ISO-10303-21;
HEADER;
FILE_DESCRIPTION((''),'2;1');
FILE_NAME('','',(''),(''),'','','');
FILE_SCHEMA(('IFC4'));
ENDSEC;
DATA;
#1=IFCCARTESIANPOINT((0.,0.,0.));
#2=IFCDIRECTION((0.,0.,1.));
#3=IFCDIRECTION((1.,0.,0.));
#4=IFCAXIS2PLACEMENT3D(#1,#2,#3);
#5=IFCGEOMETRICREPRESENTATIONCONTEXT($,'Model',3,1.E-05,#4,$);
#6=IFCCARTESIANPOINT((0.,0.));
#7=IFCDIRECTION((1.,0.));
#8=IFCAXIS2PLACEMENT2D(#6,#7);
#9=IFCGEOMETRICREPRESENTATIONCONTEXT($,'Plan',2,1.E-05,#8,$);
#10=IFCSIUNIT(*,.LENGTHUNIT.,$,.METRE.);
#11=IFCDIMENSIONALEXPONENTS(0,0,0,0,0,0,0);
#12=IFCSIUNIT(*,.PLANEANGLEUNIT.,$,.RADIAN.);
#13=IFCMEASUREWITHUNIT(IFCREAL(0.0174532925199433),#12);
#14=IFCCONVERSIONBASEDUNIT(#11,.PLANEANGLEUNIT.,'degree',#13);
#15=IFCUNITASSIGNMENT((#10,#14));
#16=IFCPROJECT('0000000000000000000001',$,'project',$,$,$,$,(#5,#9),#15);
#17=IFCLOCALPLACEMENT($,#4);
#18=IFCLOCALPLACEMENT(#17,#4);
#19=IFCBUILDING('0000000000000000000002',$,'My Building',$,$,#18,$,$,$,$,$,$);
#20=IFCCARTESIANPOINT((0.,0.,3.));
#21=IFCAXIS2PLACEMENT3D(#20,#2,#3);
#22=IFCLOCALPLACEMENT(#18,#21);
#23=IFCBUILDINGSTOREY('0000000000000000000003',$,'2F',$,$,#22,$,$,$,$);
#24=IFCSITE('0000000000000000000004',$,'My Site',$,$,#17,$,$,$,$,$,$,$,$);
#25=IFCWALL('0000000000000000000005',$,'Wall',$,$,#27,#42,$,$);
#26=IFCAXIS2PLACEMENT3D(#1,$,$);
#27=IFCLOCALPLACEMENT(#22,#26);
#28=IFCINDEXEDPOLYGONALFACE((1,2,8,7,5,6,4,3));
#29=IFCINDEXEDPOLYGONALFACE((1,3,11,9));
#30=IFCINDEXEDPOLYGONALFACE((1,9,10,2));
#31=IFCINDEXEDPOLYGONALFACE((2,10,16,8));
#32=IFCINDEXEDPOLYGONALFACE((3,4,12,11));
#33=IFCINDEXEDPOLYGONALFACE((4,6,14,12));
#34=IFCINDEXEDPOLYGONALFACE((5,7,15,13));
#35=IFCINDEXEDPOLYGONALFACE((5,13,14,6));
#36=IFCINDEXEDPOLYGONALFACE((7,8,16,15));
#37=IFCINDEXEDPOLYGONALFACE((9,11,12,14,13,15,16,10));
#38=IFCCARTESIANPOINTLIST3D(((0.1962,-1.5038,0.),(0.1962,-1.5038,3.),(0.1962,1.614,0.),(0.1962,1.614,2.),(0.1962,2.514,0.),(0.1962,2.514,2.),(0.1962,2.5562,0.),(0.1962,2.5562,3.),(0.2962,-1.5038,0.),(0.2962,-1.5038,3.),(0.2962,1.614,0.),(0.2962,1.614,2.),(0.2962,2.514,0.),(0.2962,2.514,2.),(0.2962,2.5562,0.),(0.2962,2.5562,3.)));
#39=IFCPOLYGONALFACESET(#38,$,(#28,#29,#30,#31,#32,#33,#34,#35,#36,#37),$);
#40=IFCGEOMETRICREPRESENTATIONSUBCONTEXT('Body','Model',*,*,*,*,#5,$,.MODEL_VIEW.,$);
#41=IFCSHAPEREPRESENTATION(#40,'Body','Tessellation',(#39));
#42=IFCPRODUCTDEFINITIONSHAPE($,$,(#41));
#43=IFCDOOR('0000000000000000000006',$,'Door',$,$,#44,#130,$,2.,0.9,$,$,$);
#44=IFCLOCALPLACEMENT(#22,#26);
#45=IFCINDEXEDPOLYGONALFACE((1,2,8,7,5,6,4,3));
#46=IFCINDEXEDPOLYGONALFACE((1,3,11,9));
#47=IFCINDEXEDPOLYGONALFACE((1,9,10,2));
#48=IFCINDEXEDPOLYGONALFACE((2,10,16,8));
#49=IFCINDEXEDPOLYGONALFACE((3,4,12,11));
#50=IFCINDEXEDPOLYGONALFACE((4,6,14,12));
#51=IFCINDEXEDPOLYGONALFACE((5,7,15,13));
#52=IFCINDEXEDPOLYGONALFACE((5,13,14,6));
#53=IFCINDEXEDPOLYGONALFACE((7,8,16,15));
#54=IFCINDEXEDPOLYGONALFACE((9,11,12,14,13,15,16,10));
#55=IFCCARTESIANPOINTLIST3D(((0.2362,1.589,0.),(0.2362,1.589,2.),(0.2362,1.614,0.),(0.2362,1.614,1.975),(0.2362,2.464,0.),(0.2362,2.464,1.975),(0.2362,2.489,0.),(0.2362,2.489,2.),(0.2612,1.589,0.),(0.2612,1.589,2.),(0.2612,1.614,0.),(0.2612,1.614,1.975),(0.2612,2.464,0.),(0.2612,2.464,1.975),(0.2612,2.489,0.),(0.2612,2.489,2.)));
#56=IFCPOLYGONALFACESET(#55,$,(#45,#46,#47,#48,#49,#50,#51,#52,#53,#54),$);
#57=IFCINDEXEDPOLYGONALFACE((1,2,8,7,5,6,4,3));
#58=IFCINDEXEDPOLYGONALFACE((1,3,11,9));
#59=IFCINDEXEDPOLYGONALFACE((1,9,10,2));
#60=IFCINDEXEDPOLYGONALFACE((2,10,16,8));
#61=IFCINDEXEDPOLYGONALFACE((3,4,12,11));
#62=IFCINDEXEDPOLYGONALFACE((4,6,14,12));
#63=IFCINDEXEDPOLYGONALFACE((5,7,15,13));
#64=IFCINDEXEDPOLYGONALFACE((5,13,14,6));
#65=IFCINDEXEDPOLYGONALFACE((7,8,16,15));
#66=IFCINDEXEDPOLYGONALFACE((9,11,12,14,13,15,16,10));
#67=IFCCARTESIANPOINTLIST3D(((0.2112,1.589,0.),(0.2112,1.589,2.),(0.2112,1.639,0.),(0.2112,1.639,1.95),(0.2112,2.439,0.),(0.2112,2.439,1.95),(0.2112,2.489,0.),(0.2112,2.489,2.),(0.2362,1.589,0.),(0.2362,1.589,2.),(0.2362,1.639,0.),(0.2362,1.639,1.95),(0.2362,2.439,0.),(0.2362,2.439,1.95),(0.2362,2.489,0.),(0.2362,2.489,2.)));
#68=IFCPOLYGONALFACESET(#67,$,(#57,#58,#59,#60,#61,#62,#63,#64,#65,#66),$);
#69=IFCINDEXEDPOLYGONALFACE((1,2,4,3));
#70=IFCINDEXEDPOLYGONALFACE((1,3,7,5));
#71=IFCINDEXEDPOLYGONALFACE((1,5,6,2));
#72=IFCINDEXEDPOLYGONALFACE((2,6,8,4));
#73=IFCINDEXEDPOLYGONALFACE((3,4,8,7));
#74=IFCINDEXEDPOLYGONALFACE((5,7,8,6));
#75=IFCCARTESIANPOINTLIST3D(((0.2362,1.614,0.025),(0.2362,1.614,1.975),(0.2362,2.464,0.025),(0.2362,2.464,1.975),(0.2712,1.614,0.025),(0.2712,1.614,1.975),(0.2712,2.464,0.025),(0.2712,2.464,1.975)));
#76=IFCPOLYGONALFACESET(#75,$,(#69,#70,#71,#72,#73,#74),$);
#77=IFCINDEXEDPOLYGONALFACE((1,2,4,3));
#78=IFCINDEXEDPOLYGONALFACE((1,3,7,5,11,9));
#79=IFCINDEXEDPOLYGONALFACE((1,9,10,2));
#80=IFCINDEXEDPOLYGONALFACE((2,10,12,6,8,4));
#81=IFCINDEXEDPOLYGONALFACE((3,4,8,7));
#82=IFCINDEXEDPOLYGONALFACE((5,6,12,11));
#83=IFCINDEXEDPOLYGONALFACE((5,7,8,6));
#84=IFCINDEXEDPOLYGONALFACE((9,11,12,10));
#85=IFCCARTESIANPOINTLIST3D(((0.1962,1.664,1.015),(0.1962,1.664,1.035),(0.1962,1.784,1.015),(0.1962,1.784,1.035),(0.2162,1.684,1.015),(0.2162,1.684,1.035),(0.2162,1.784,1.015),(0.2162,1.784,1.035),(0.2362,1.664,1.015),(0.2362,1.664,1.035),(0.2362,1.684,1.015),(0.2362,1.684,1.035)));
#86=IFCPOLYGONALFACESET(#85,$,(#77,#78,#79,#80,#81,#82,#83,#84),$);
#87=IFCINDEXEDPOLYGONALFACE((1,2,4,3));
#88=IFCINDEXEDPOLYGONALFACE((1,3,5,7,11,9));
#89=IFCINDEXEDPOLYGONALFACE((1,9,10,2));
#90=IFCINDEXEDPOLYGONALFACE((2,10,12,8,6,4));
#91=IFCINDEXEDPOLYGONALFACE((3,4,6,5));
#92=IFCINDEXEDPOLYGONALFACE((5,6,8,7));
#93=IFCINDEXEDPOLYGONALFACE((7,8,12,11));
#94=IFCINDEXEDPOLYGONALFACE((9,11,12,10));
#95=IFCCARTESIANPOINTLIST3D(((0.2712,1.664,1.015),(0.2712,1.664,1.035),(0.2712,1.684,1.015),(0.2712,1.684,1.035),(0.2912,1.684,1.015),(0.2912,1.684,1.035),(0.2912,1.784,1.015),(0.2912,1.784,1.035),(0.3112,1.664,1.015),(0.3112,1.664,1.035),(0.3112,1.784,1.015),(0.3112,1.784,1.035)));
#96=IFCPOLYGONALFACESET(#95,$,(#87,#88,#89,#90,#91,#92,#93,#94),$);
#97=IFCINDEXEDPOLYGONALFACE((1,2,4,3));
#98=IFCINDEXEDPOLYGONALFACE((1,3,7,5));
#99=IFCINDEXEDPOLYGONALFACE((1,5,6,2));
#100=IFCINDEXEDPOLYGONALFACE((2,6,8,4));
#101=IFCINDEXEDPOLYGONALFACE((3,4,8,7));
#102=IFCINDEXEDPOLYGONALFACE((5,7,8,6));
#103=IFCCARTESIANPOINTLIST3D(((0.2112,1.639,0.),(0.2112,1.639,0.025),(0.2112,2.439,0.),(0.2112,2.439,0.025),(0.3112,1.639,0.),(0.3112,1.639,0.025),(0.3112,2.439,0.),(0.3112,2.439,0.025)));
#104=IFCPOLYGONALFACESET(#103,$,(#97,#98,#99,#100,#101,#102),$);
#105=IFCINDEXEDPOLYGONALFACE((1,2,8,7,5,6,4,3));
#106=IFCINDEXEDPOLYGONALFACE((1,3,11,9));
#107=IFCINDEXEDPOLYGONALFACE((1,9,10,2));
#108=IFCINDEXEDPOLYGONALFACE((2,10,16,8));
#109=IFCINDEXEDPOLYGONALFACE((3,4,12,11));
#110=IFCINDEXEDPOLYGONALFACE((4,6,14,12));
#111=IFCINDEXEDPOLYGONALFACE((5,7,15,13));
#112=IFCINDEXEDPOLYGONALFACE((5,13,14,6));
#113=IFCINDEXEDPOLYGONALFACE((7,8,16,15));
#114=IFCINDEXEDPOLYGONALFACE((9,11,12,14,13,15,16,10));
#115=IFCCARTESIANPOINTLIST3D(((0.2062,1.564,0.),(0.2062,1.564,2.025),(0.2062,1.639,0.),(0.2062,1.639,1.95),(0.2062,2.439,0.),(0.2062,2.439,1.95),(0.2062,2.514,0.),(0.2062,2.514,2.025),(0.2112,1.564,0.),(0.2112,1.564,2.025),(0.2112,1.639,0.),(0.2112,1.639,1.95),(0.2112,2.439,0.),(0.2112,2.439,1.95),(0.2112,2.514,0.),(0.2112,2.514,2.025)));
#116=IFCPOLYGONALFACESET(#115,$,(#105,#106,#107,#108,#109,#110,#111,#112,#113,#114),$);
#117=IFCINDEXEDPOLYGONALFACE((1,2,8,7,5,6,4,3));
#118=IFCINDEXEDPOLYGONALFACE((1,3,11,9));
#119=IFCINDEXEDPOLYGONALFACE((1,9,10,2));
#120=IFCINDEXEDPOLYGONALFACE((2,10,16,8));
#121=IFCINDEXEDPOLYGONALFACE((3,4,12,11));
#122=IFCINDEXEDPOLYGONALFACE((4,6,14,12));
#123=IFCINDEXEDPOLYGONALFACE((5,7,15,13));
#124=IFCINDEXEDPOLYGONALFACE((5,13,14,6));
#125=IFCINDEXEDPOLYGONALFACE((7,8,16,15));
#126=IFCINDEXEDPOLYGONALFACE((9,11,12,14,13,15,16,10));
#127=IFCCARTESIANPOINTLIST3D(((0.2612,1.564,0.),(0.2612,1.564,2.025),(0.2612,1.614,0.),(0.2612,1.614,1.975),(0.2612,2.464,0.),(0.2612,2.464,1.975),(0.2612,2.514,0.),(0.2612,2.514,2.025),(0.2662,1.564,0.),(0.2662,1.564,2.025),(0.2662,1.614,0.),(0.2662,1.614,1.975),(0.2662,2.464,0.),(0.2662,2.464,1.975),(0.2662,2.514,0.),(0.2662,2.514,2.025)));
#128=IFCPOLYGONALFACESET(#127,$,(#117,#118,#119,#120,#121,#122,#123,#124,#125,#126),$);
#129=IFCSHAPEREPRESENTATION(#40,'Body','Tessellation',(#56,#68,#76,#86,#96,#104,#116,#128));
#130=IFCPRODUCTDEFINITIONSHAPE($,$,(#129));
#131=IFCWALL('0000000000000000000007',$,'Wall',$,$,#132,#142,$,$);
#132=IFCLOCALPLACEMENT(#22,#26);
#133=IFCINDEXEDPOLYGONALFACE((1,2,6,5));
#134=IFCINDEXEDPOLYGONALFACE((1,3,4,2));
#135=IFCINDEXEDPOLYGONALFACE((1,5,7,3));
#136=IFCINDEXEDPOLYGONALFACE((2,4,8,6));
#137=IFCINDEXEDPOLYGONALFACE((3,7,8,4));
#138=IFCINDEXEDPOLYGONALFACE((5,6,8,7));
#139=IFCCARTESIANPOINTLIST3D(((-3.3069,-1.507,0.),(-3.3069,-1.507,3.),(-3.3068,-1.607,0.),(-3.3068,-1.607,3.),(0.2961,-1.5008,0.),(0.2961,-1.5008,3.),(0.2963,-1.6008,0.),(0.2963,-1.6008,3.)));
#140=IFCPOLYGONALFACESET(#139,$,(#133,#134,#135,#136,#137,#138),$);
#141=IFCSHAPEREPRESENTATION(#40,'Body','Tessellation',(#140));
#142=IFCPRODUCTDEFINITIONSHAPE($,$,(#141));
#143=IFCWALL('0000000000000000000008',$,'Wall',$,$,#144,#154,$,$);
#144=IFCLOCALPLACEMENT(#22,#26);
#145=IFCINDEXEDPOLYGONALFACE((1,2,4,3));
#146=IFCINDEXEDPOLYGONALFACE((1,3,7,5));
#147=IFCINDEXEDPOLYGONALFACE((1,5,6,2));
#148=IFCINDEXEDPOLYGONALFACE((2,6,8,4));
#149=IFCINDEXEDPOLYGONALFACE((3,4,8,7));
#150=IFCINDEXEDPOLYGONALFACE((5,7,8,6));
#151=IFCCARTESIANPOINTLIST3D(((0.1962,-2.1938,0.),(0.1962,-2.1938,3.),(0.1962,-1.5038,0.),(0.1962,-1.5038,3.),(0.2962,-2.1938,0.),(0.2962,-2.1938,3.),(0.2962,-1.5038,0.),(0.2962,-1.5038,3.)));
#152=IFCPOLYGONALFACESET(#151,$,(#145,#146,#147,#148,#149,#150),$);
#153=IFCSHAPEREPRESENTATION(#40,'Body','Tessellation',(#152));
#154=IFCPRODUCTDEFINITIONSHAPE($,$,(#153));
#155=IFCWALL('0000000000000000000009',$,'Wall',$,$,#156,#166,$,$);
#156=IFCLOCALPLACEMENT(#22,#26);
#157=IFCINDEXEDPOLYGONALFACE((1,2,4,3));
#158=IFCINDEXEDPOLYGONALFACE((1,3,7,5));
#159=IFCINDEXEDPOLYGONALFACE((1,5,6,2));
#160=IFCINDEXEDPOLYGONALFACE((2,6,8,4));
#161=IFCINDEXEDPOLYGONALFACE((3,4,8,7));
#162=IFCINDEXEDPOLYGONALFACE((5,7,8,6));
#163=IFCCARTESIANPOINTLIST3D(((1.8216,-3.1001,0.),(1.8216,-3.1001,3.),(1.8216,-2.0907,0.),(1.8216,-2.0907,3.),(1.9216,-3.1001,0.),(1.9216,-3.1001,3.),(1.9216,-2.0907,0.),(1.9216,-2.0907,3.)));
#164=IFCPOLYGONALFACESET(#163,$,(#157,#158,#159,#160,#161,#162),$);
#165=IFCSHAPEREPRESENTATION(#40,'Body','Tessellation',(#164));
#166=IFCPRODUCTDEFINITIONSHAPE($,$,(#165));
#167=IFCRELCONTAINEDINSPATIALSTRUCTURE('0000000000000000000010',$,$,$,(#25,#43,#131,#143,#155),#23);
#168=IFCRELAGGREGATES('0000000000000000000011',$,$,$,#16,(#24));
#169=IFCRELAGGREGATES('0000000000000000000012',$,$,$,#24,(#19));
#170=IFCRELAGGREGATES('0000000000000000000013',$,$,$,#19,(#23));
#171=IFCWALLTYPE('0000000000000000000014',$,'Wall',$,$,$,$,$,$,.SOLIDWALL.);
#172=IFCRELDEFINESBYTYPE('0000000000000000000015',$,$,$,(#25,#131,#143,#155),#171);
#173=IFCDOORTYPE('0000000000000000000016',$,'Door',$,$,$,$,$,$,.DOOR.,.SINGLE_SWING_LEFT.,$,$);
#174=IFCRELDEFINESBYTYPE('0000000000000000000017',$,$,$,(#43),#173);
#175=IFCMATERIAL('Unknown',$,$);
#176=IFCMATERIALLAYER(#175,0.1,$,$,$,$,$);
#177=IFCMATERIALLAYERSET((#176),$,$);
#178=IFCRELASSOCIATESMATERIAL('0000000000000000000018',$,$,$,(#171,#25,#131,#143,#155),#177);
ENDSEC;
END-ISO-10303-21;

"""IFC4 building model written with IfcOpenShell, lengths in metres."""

from ifc_helpers import new_model, entity, si_unit, converted_unit, frame, origin_with_axes, origin_2d_with_axis, place, context, subcontext, project, spatial, line, indexed_curve, outline, extrude, shape, source, transform, mapped, material, layer, layer_set, layer_usage, type_object, type_shapes, element, fill, save


model = new_model("IFC4")

# Units and contexts
model_context = context("Model", 3, precision=1e-05, world=origin_with_axes())
plan_context = context("Plan", 2, precision=1e-05, world=origin_2d_with_axis())
body_context_1 = subcontext(model_context, "Body", "Model", "MODEL_VIEW")
body_context_2 = subcontext(plan_context, "Body", "Plan", "PLAN_VIEW")
ifc_project = project(units=[si_unit("LENGTHUNIT", "METRE"), converted_unit("PLANEANGLEUNIT", "degree", entity("IfcReal", 0.0174532925199433), si_unit("PLANEANGLEUNIT", "RADIAN"), dimensions=[0, 0, 0, 0, 0, 0, 0])], contexts=[model_context, plan_context])

# Site, building, storey
site_placement = place(None, origin_with_axes())
site = spatial("IfcSite", under=ifc_project, at=site_placement, Name="My Site")
building_placement = place(site_placement, origin_with_axes())
building = spatial("IfcBuilding", under=site, at=building_placement, Name="My Building")
storey_placement = place(building_placement, frame((0.0, 0.0, 3.0), z_axis=(0.0, 0.0, 1.0), x_axis=(1.0, 0.0, 0.0)))
storey = spatial("IfcBuildingStorey", under=building, at=storey_placement, Name="2F")

# Shared definitions
ifc_material = material(Name="Unknown")

# Shared definitions
ifc_layer_1 = layer(ifc_material, 0.1)
ifc_layer_set_1 = layer_set([ifc_layer_1])
wall_type = type_object("IfcWallType", Name="Wall", PredefinedType="SOLIDWALL", material=ifc_layer_set_1)

# Wall, opening, door
shared_shape_1 = source(origin_with_axes(), body_context_1, "Body", "SweptSolid", [
    extrude(outline(indexed_curve([(0.0, 0.0), (0.9, 0.0), (0.9, 2.0), (0.0, 2.0)], segments=[line(1, 2, 3, 4, 1)])), frame((0.0, -0.6, 0.0), z_axis=(0.0, -1.0, 0.0), x_axis=(1.0, 0.0, 0.0)), (0.0, 0.0, -1.0), 1.2),
])
door_type_1 = type_object("IfcDoorType", Name="Door", OperationType="SINGLE_SWING_LEFT", PredefinedType="DOOR")
shared_shape_2 = source(origin_with_axes(), body_context_1, "Body", "SweptSolid", [
    extrude(outline(indexed_curve([(0.0, 0.0), (0.0, 2.0), (0.9, 2.0), (0.9, 0.0), (0.875, 0.0), (0.875, 1.975), (0.025, 1.975), (0.025, 0.0)], segments=[line(1, 2, 3, 4, 5, 6, 7, 8, 1)])), frame((0.0, 0.025, 0.0), z_axis=(0.0, -1.0, 0.0), x_axis=(1.0, 0.0, 0.0)), (0.0, 0.0, -1.0), 0.025),
    extrude(outline(indexed_curve([(0.0, 0.0), (0.0, 2.0), (0.9, 2.0), (0.9, 0.0), (0.85, 0.0), (0.85, 1.95), (0.05, 1.95), (0.05, 0.0)], segments=[line(1, 2, 3, 4, 5, 6, 7, 8, 1)])), frame((0.0, 0.0, 0.0), z_axis=(0.0, -1.0, 0.0), x_axis=(1.0, 0.0, 0.0)), (0.0, 0.0, -1.0), 0.025),
    extrude(outline(indexed_curve([(0.0, 0.0), (0.85, 0.0), (0.85, 0.035), (0.0, 0.035)], segments=[line(1, 2, 3, 4, 1)])), frame((0.025, 0.025, 0.025), z_axis=(0.0, 0.0, 1.0), x_axis=(1.0, 0.0, 0.0)), (0.0, 0.0, 1.0), 1.95),
    extrude(outline(indexed_curve([(0.0, 0.0), (0.0, -0.04), (-0.12, -0.04), (-0.12, -0.02), (-0.02, -0.02), (-0.02, 0.0)], segments=[line(1, 2, 3, 4, 5, 6, 1)])), frame((0.825, 0.025, 1.015), z_axis=(0.0, 0.0, 1.0), x_axis=(1.0, 0.0, 0.0)), (0.0, 0.0, 1.0), 0.02),
    extrude(outline(indexed_curve([(0.0, 0.0), (0.0, 0.04), (-0.12, 0.04), (-0.12, 0.02), (-0.02, 0.02), (-0.02, 0.0)], segments=[line(1, 2, 3, 4, 5, 6, 1)])), frame((0.825, 0.06, 1.015), z_axis=(0.0, 0.0, 1.0), x_axis=(1.0, 0.0, 0.0)), (0.0, 0.0, 1.0), 0.02),
    extrude(outline(indexed_curve([(0.0, 0.0), (0.8, 0.0), (0.8, 0.1), (0.0, 0.1)], segments=[line(1, 2, 3, 4, 1)])), frame((0.05, 0.0, 0.0), z_axis=(0.0, 0.0, 1.0), x_axis=(1.0, 0.0, 0.0)), (0.0, 0.0, 1.0), 0.025),
    extrude(outline(indexed_curve([(0.0, 0.0), (0.0, 2.025), (0.95, 2.025), (0.95, 0.0), (0.875, 0.0), (0.875, 1.95), (0.075, 1.95), (0.075, 0.0)], segments=[line(1, 2, 3, 4, 5, 6, 7, 8, 1)])), frame((-0.025, -0.005, 0.0), z_axis=(0.0, -1.0, 0.0), x_axis=(1.0, 0.0, 0.0)), (0.0, 0.0, -1.0), 0.005),
    extrude(outline(indexed_curve([(0.0, 0.0), (0.0, 2.025), (0.95, 2.025), (0.95, 0.0), (0.9, 0.0), (0.9, 1.975), (0.05, 1.975), (0.05, 0.0)], segments=[line(1, 2, 3, 4, 5, 6, 7, 8, 1)])), frame((-0.025, 0.05, 0.0), z_axis=(0.0, -1.0, 0.0), x_axis=(1.0, 0.0, 0.0)), (0.0, 0.0, -1.0), 0.005),
])
shared_shape_3 = source(origin_with_axes(), body_context_2, "Body", "Curve2D", [
    entity("IfcIndexedPolyCurve", entity("IfcCartesianPointList2D", [[0.0, 0.0], [0.0, 0.05], [0.025, 0.05], [0.025, 0.025], [0.05, 0.025], [0.05, 0.0]]), [entity("IfcLineIndex", [1, 2, 3, 4, 5, 6, 1])]),
    entity("IfcIndexedPolyCurve", entity("IfcCartesianPointList2D", [[0.9, 0.0], [0.9, 0.05], [0.875, 0.05], [0.875, 0.025], [0.85, 0.025], [0.85, 0.0]]), [entity("IfcLineIndex", [1, 2, 3, 4, 5, 6, 1])]),
    entity("IfcTrimmedCurve", entity("IfcEllipse", entity("IfcAxis2Placement2D", entity("IfcCartesianPoint", [0.06, 0.05]), entity("IfcDirection", [1.0, 0.0])), 0.815, 0.85), [entity("IfcCartesianPoint", [0.875, 0.05])], [entity("IfcCartesianPoint", [0.06, 0.9])], True, "CARTESIAN"),
    entity("IfcIndexedPolyCurve", entity("IfcCartesianPointList2D", [[0.025, 0.05], [0.06, 0.05], [0.06, 0.9], [0.025, 0.9]]), [entity("IfcLineIndex", [1, 2, 3, 4, 1])]),
])
type_shapes(door_type_1, [shared_shape_2, shared_shape_3])
ifc_layer_usage_1 = layer_usage(ifc_layer_set_1, "AXIS2", "POSITIVE", 0.0)
wall_1_placement = place(storey_placement, frame((0.2962, -1.5038, 0.0), z_axis=(0.0, 0.0, 1.0), x_axis=(0.0, 1.0, 0.0)))
wall_1 = element("IfcWall", 1, at=wall_1_placement, inside=storey, type_object=wall_type, material=ifc_layer_usage_1, Name="Wall", context=body_context_1, shape_type="SweptSolid", body=[
    extrude(outline(indexed_curve([(0.0, 0.0), (0.0, 0.1), (4.06, 0.1), (4.06, 0.0)], segments=[line(1, 2, 3, 4, 1)])), origin_with_axes(), (0.0, 0.0, 1.0), 3.0),
])
opening_1_placement = place(wall_1_placement, frame((3.1178, 0.0, 0.0), z_axis=(0.0, 0.0, 1.0), x_axis=(1.0, 0.0, 0.0)))
opening_1 = element("IfcOpeningElement", 2, at=opening_1_placement, cuts=wall_1, PredefinedType="OPENING", context=body_context_1, shape_type="MappedRepresentation", body=[
    mapped(shared_shape_1, transform((0.0, 0.0, 0.0), x_axis=(1.0, 0.0, 0.0), y_axis=(0.0, 1.0, 0.0), z_axis=(0.0, 0.0, 1.0), scale=1.0)),
])
door_1_placement = place(opening_1_placement, frame((0.875, 0.085, 0.0), z_axis=(0.0, 0.0, 1.0), x_axis=(-1.0, 0.0, 0.0)))
door_1 = element("IfcDoor", 3, at=door_1_placement, inside=storey, type_object=door_type_1, Name="Door", OverallHeight=2.0, OverallWidth=0.9, shapes=[
    shape(body_context_1, "Body", "MappedRepresentation", [mapped(shared_shape_2, transform((0.0, 0.0, 0.0), x_axis=(1.0, 0.0, 0.0), y_axis=(0.0, 1.0, 0.0), z_axis=(0.0, 0.0, 1.0), scale=1.0))]),
    shape(body_context_2, "Body", "MappedRepresentation", [mapped(shared_shape_3, transform((0.0, 0.0, 0.0), x_axis=(1.0, 0.0, 0.0), y_axis=(0.0, 1.0, 0.0), z_axis=(0.0, 0.0, 1.0), scale=1.0))]),
])
fill(opening_1, door_1)

# Walls
ifc_layer_usage_2 = layer_usage(ifc_layer_set_1, "AXIS2", "POSITIVE", 0.0)
wall_2_placement = place(storey_placement, frame((-3.3068, -1.607, 0.0), z_axis=(0.0, 0.0, 1.0), x_axis=(0.999999, 0.001712, 0.0)))
element("IfcWall", 4, at=wall_2_placement, inside=storey, type_object=wall_type, material=ifc_layer_usage_2, Name="Wall", context=body_context_1, shape_type="SweptSolid", body=[
    extrude(outline(indexed_curve([(0.0, 0.0), (0.0, 0.1), (3.6031, 0.1), (3.6031, 0.0)], segments=[line(1, 2, 3, 4, 1)])), origin_with_axes(), (0.0, 0.0, 1.0), 3.0),
])
ifc_layer_usage_3 = layer_usage(ifc_layer_set_1, "AXIS2", "POSITIVE", 0.0)
wall_3_placement = place(storey_placement, frame((0.1962, -1.5038, 0.0), z_axis=(0.0, 0.0, 1.0), x_axis=(0.0, -1.0, 0.0)))
element("IfcWall", 5, at=wall_3_placement, inside=storey, type_object=wall_type, material=ifc_layer_usage_3, Name="Wall", context=body_context_1, shape_type="SweptSolid", body=[
    extrude(outline(indexed_curve([(0.0, 0.0), (0.0, 0.1), (0.69, 0.1), (0.69, 0.0)], segments=[line(1, 2, 3, 4, 1)])), origin_with_axes(), (0.0, 0.0, 1.0), 3.0),
])
ifc_layer_usage_4 = layer_usage(ifc_layer_set_1, "AXIS2", "POSITIVE", 0.0)
wall_4_placement = place(storey_placement, frame((1.9216, -3.1001, 0.0), z_axis=(0.0, 0.0, 1.0), x_axis=(0.000002, 1.0, 0.0)))
element("IfcWall", 6, at=wall_4_placement, inside=storey, type_object=wall_type, material=ifc_layer_usage_4, Name="Wall", context=body_context_1, shape_type="SweptSolid", body=[
    extrude(outline(indexed_curve([(0.0, 0.0), (0.0, 0.1), (1.0094, 0.1), (1.0094, 0.0)], segments=[line(1, 2, 3, 4, 1)])), origin_with_axes(), (0.0, 0.0, 1.0), 3.0),
])

save(model, "model.ifc")
